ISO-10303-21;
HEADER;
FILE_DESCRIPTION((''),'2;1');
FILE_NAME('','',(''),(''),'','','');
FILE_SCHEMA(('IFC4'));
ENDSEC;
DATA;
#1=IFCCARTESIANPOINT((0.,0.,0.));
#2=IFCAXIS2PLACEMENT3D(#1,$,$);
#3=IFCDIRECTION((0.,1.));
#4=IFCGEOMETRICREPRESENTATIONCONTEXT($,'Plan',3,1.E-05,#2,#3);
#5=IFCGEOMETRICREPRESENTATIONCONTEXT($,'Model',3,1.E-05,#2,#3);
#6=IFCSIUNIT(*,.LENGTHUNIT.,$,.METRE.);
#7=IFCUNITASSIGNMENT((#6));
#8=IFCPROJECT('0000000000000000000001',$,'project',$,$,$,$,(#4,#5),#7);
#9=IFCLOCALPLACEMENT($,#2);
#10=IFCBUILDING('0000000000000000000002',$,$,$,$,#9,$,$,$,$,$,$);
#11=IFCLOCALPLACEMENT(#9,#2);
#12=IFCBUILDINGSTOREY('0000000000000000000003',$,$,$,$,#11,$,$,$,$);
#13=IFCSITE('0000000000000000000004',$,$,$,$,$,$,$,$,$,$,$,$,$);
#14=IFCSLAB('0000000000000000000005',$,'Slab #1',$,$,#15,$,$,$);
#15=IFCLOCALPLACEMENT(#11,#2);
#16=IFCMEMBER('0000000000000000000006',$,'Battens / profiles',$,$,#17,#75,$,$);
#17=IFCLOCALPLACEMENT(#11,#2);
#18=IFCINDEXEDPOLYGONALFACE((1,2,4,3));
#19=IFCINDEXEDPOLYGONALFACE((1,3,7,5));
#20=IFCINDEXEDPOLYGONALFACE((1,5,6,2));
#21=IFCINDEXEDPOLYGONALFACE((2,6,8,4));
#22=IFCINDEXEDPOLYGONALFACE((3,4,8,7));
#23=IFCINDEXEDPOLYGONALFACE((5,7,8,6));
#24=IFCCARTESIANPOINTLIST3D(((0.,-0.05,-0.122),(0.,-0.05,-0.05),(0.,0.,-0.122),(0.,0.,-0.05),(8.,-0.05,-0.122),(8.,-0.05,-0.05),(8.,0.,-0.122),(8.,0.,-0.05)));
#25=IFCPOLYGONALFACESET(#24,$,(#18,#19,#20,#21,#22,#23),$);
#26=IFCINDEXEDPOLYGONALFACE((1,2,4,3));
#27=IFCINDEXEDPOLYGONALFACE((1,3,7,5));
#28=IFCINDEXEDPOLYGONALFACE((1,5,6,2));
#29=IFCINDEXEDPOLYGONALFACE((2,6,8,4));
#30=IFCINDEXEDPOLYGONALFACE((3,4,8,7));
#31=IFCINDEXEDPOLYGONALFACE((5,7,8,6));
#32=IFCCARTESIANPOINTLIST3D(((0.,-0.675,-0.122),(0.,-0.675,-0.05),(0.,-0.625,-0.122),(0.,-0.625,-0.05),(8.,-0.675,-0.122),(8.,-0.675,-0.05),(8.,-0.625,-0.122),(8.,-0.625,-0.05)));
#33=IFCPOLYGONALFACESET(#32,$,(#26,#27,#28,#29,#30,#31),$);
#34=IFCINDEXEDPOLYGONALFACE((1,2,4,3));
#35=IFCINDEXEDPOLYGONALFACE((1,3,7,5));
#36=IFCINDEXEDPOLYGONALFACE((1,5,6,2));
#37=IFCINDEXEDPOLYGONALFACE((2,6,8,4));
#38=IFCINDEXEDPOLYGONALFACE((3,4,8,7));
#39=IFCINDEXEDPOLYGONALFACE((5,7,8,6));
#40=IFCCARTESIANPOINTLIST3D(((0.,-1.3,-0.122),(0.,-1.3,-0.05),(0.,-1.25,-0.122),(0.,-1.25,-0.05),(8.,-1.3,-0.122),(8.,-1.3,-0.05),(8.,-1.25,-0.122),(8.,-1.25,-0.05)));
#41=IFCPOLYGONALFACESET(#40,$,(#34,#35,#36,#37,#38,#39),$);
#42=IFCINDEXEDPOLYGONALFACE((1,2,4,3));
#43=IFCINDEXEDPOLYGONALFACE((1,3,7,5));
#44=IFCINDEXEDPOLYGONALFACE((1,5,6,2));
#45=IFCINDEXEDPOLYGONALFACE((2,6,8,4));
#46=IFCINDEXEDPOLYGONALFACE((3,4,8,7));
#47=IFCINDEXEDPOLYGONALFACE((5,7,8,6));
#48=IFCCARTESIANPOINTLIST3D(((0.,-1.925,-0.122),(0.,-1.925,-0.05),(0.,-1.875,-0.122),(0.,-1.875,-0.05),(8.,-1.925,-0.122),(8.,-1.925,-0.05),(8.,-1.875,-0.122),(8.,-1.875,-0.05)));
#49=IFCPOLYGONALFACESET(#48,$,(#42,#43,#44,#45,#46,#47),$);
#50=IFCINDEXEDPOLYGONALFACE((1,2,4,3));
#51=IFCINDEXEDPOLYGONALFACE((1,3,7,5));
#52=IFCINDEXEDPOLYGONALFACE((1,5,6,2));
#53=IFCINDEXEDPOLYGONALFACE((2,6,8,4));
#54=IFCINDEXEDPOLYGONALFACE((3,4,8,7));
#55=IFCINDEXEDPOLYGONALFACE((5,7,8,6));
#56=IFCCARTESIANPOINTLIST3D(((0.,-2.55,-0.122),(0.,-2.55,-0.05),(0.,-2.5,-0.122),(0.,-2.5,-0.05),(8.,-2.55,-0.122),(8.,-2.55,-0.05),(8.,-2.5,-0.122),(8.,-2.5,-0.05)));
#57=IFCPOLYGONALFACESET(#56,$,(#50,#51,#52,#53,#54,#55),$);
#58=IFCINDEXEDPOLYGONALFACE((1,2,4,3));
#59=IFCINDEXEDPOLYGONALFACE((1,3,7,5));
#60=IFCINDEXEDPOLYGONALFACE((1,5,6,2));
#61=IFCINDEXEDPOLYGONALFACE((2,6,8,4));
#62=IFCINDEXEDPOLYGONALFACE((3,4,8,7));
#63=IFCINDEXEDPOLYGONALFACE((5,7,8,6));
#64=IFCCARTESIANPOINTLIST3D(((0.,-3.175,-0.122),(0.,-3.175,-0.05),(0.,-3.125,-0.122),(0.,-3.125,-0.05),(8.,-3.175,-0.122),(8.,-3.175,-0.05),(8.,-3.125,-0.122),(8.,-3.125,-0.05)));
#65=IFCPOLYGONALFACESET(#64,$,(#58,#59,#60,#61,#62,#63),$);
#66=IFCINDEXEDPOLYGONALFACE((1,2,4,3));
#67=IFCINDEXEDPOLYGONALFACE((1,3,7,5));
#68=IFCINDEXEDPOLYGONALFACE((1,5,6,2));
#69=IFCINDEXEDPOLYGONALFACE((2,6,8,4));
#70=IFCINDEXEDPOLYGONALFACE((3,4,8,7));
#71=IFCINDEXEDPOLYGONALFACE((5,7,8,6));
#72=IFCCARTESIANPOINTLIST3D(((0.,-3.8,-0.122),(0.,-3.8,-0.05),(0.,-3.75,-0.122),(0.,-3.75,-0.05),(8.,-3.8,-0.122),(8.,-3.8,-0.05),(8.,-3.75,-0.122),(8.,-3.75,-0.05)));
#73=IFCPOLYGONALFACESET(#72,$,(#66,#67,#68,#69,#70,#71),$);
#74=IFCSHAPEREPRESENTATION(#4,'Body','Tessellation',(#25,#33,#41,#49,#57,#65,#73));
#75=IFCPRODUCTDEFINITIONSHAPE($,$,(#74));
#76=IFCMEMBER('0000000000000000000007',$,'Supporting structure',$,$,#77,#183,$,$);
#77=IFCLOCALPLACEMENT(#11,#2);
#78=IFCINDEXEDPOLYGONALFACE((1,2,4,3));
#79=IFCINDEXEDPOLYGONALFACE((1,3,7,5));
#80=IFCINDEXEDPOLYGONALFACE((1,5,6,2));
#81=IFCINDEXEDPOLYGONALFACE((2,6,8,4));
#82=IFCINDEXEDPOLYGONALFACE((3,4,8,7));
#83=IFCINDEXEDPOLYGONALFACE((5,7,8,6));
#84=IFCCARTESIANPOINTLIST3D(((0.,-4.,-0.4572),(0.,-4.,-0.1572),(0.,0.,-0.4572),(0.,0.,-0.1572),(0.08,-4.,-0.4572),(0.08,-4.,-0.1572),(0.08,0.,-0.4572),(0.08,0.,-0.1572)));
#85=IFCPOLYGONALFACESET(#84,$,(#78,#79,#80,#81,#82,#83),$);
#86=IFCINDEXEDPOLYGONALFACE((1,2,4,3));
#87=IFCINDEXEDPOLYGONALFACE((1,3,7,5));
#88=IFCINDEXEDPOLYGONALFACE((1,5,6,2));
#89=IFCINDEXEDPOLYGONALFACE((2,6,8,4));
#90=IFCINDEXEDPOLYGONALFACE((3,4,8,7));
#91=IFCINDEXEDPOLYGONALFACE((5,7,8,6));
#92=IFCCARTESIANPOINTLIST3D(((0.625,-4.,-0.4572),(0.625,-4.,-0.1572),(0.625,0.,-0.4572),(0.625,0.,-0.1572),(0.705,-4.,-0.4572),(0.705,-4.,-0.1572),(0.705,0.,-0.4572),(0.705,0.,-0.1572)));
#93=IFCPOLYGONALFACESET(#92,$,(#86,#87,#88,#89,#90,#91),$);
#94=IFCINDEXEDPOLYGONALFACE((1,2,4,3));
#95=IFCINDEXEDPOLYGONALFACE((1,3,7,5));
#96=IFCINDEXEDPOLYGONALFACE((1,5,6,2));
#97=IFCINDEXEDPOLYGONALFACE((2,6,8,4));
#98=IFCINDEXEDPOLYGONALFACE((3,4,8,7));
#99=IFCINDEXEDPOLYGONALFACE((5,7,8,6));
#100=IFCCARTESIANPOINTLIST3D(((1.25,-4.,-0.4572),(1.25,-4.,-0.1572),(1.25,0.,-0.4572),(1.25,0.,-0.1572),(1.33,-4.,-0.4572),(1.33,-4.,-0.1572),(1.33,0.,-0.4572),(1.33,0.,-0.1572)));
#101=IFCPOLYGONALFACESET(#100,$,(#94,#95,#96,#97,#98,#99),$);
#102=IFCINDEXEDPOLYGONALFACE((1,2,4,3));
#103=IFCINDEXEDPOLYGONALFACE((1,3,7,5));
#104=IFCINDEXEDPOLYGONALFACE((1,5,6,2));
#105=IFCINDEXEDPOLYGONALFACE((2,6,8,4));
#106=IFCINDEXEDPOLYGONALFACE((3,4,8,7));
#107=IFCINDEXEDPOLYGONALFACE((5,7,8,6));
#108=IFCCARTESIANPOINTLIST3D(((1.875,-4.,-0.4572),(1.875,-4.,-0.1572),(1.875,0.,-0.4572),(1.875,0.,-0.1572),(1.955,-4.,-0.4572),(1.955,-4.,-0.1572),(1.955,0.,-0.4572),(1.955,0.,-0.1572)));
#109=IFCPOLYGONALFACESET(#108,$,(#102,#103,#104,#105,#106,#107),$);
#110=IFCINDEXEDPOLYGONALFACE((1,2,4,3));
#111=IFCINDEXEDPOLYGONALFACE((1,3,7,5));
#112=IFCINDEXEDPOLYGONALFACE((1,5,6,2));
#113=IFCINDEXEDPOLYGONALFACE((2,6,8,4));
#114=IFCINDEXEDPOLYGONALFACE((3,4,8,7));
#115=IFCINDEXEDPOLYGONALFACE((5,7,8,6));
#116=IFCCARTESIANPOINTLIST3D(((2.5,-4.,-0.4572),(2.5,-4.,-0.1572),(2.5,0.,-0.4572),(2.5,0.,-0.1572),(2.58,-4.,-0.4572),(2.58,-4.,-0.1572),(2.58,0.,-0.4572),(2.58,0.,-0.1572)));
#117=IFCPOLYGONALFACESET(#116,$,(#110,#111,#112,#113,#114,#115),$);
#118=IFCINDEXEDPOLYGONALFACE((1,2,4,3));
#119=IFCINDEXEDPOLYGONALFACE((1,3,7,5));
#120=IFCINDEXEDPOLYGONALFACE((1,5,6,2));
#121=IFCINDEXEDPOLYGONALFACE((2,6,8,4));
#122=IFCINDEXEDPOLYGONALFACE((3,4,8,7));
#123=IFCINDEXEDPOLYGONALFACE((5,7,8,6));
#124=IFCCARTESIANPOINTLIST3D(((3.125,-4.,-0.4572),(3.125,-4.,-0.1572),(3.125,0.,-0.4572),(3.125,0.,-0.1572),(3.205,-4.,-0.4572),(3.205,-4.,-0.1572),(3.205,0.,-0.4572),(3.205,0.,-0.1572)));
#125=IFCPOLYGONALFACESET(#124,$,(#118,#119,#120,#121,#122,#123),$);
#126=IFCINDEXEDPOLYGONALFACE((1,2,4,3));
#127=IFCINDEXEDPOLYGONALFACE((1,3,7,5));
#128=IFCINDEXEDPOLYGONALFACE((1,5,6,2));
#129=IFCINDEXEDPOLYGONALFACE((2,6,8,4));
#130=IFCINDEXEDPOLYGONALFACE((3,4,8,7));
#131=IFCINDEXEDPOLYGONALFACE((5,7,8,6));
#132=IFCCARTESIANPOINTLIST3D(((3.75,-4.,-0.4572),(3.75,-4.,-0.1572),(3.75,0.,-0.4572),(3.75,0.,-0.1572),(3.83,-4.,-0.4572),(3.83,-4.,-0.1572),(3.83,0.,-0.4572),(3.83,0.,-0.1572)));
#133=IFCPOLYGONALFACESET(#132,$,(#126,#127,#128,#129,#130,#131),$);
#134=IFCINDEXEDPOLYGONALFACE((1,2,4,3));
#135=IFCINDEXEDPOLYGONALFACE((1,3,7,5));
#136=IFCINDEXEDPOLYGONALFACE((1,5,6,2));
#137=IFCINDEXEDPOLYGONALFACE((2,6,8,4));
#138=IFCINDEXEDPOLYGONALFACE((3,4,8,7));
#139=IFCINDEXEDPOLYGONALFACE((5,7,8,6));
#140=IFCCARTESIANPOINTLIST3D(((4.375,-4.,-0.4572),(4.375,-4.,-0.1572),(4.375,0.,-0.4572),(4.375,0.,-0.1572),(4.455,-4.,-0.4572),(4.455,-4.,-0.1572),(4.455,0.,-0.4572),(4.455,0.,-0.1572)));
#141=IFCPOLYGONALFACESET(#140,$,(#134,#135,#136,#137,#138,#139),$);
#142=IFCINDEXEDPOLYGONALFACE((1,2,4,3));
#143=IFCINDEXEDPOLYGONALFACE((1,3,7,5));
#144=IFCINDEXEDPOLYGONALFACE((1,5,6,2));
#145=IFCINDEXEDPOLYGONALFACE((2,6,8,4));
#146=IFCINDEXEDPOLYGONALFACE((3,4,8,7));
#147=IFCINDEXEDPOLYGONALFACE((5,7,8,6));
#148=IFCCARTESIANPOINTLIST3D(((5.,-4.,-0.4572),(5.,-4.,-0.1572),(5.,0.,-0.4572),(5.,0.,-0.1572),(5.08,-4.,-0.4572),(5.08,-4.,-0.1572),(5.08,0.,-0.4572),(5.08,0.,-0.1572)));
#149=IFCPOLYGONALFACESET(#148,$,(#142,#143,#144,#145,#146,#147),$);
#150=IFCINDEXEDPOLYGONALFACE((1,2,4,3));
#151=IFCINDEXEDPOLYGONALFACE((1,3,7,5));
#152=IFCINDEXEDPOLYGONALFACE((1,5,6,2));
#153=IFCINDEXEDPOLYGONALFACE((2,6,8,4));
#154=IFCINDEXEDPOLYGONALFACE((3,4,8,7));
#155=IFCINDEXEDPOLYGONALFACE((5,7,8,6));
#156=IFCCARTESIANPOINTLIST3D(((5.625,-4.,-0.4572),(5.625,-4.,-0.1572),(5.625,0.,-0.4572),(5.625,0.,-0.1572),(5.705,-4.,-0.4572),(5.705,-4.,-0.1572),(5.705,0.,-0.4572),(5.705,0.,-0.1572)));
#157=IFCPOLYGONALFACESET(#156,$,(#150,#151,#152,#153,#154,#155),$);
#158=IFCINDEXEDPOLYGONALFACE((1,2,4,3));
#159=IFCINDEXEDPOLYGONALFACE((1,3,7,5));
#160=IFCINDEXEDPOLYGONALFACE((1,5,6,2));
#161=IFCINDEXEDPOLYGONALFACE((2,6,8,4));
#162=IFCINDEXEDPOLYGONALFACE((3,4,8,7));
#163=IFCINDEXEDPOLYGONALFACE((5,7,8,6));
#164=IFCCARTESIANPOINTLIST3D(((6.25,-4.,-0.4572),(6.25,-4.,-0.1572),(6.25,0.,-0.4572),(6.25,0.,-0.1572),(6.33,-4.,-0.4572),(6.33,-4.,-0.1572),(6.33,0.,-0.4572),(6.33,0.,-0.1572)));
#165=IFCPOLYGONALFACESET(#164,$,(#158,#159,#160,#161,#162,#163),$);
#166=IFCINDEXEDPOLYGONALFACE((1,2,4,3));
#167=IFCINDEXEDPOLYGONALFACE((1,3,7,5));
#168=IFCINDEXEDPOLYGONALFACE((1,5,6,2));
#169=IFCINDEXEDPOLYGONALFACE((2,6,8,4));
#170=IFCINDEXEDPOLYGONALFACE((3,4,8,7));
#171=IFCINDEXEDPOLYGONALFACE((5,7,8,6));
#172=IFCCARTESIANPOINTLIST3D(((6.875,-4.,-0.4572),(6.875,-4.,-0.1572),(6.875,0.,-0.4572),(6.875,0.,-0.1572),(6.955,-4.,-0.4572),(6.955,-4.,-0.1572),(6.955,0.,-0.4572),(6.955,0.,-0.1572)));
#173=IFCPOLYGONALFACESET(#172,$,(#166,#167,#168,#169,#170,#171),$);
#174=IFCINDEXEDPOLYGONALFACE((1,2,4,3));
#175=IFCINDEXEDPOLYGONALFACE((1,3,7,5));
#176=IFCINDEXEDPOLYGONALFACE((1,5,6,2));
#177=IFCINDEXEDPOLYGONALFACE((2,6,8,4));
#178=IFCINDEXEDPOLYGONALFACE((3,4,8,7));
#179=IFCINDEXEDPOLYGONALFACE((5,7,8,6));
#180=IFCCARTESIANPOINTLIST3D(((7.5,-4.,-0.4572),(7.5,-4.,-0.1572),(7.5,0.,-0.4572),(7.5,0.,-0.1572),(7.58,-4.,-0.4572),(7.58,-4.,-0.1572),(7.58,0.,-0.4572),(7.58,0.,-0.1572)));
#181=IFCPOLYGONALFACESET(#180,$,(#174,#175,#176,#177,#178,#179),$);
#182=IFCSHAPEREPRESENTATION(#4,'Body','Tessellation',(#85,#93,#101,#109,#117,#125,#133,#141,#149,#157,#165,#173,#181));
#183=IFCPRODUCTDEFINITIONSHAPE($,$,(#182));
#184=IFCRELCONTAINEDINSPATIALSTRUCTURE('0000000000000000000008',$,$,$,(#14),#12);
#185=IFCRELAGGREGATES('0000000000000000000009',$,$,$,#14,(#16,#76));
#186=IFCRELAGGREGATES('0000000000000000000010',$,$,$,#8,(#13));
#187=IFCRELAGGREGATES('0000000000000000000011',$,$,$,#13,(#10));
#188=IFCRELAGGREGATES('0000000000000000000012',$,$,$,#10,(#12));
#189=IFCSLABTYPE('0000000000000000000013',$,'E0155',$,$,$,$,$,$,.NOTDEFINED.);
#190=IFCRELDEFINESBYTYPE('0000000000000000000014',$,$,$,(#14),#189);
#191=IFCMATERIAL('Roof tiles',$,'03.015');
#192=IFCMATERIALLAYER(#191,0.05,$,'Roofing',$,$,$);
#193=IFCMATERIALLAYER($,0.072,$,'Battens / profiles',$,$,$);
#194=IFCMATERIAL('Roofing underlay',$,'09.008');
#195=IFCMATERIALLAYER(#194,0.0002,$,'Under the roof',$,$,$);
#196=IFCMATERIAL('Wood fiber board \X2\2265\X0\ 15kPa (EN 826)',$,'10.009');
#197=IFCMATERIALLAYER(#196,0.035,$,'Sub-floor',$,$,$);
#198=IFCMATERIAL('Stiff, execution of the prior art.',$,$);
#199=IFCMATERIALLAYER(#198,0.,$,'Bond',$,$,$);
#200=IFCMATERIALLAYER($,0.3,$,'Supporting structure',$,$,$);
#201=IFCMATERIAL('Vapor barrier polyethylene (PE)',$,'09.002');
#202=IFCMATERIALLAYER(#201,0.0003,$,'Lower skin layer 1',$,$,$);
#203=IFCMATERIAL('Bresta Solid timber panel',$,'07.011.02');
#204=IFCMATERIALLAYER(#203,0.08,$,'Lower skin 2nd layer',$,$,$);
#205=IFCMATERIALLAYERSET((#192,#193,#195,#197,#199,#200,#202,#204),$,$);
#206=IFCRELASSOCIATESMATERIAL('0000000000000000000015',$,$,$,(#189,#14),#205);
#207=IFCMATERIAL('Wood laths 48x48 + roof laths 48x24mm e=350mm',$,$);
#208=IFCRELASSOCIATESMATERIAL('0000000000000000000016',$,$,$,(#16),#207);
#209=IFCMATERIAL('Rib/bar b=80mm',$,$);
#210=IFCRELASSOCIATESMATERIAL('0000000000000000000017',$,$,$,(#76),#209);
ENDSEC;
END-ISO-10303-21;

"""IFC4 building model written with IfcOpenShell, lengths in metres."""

from ifc_helpers import new_model, si_unit, direction, frame, frame_2d, origin, place, context, project, spatial, rectangle, extrude, material, layer, layer_set, type_object, element, aggregate, save


model = new_model("IFC4")

# Units and contexts
plan_context = context("Plan", 3, precision=1e-05, world=origin(), true_north=direction((0.0, 1.0)))
model_context = context("Model", 3, precision=1e-05, world=origin(), true_north=direction((0.0, 1.0)))
ifc_project = project(units=[si_unit("LENGTHUNIT", "METRE")], contexts=[plan_context, model_context])

# Site, building, storey
site = spatial("IfcSite", under=ifc_project)
building_placement = place(None, origin())
building = spatial("IfcBuilding", under=site, at=building_placement)
storey_placement = place(building_placement, origin())
storey = spatial("IfcBuildingStorey", under=building, at=storey_placement)

# Slab, members
ifc_material_1 = material(Name="Roof tiles", Category="03.015")
ifc_layer_1 = layer(ifc_material_1, 0.05, Name="Roofing")
ifc_layer_2 = layer(None, 0.072, Name="Battens / profiles")
ifc_material_2 = material(Name="Roofing underlay", Category="09.008")
ifc_layer_3 = layer(ifc_material_2, 0.0002, Name="Under the roof")
ifc_material_3 = material(Name="Wood fiber board ≥ 15kPa (EN 826)", Category="10.009")
ifc_layer_4 = layer(ifc_material_3, 0.035, Name="Sub-floor")
ifc_material_4 = material(Name="Stiff, execution of the prior art.")
ifc_layer_5 = layer(ifc_material_4, 0.0, Name="Bond")
ifc_layer_6 = layer(None, 0.3, Name="Supporting structure")
ifc_material_5 = material(Name="Vapor barrier polyethylene (PE)", Category="09.002")
ifc_layer_7 = layer(ifc_material_5, 0.0003, Name="Lower skin layer 1")
ifc_material_6 = material(Name="Bresta Solid timber panel", Category="07.011.02")
ifc_layer_8 = layer(ifc_material_6, 0.08, Name="Lower skin 2nd layer")
ifc_layer_set = layer_set([ifc_layer_1, ifc_layer_2, ifc_layer_3, ifc_layer_4, ifc_layer_5, ifc_layer_6, ifc_layer_7, ifc_layer_8])
slab_type = type_object("IfcSlabType", Name="E0155", PredefinedType="NOTDEFINED", material=ifc_layer_set)
slab_placement = place(None, frame((0.0, 0.0, 0.0), z_axis=(0.0, 0.0, -1.0), x_axis=(1.0, 0.0, 0.0)))
slab = element("IfcSlab", 1, at=slab_placement, inside=storey, type_object=slab_type, material=ifc_layer_set, Name="Slab #1")
ifc_material_7 = material(Name="Wood laths 48x48 + roof laths 48x24mm e=350mm")
member_1_placement = place(slab_placement, origin())
member_1 = element("IfcMember", 2, at=member_1_placement, material=ifc_material_7, Name="Battens / profiles", context=plan_context, shape_type="SweptSolid", body=[
    extrude(rectangle(XDim=0.05, YDim=0.072, at=frame_2d((0.025, 0.036), x_axis=(1.0, 0.0))), frame((0.0, 0.0, 0.05), z_axis=(1.0, 0.0, 0.0), x_axis=(0.0, 1.0, 0.0)), (0.0, 0.0, 1.0), 8.0),
    extrude(rectangle(XDim=0.05, YDim=0.072, at=frame_2d((0.025, 0.036), x_axis=(1.0, 0.0))), frame((0.0, 0.625, 0.05), z_axis=(1.0, 0.0, 0.0), x_axis=(0.0, 1.0, 0.0)), (0.0, 0.0, 1.0), 8.0),
    extrude(rectangle(XDim=0.05, YDim=0.072, at=frame_2d((0.025, 0.036), x_axis=(1.0, 0.0))), frame((0.0, 1.25, 0.05), z_axis=(1.0, 0.0, 0.0), x_axis=(0.0, 1.0, 0.0)), (0.0, 0.0, 1.0), 8.0),
    extrude(rectangle(XDim=0.05, YDim=0.072, at=frame_2d((0.025, 0.036), x_axis=(1.0, 0.0))), frame((0.0, 1.875, 0.05), z_axis=(1.0, 0.0, 0.0), x_axis=(0.0, 1.0, 0.0)), (0.0, 0.0, 1.0), 8.0),
    extrude(rectangle(XDim=0.05, YDim=0.072, at=frame_2d((0.025, 0.036), x_axis=(1.0, 0.0))), frame((0.0, 2.5, 0.05), z_axis=(1.0, 0.0, 0.0), x_axis=(0.0, 1.0, 0.0)), (0.0, 0.0, 1.0), 8.0),
    extrude(rectangle(XDim=0.05, YDim=0.072, at=frame_2d((0.025, 0.036), x_axis=(1.0, 0.0))), frame((0.0, 3.125, 0.05), z_axis=(1.0, 0.0, 0.0), x_axis=(0.0, 1.0, 0.0)), (0.0, 0.0, 1.0), 8.0),
    extrude(rectangle(XDim=0.05, YDim=0.072, at=frame_2d((0.025, 0.036), x_axis=(1.0, 0.0))), frame((0.0, 3.75, 0.05), z_axis=(1.0, 0.0, 0.0), x_axis=(0.0, 1.0, 0.0)), (0.0, 0.0, 1.0), 8.0),
])
ifc_material_8 = material(Name="Rib/bar b=80mm")
member_2_placement = place(slab_placement, origin())
member_2 = element("IfcMember", 3, at=member_2_placement, material=ifc_material_8, Name="Supporting structure", context=plan_context, shape_type="SweptSolid", body=[
    extrude(rectangle(XDim=0.08, YDim=0.3, at=frame_2d((0.04, 0.15), x_axis=(1.0, 0.0))), frame((0.0, 4.0, 0.1572), z_axis=(0.0, -1.0, 0.0), x_axis=(1.0, 0.0, 0.0)), (0.0, 0.0, 1.0), 4.0),
    extrude(rectangle(XDim=0.08, YDim=0.3, at=frame_2d((0.04, 0.15), x_axis=(1.0, 0.0))), frame((0.625, 4.0, 0.1572), z_axis=(0.0, -1.0, 0.0), x_axis=(1.0, 0.0, 0.0)), (0.0, 0.0, 1.0), 4.0),
    extrude(rectangle(XDim=0.08, YDim=0.3, at=frame_2d((0.04, 0.15), x_axis=(1.0, 0.0))), frame((1.25, 4.0, 0.1572), z_axis=(0.0, -1.0, 0.0), x_axis=(1.0, 0.0, 0.0)), (0.0, 0.0, 1.0), 4.0),
    extrude(rectangle(XDim=0.08, YDim=0.3, at=frame_2d((0.04, 0.15), x_axis=(1.0, 0.0))), frame((1.875, 4.0, 0.1572), z_axis=(0.0, -1.0, 0.0), x_axis=(1.0, 0.0, 0.0)), (0.0, 0.0, 1.0), 4.0),
    extrude(rectangle(XDim=0.08, YDim=0.3, at=frame_2d((0.04, 0.15), x_axis=(1.0, 0.0))), frame((2.5, 4.0, 0.1572), z_axis=(0.0, -1.0, 0.0), x_axis=(1.0, 0.0, 0.0)), (0.0, 0.0, 1.0), 4.0),
    extrude(rectangle(XDim=0.08, YDim=0.3, at=frame_2d((0.04, 0.15), x_axis=(1.0, 0.0))), frame((3.125, 4.0, 0.1572), z_axis=(0.0, -1.0, 0.0), x_axis=(1.0, 0.0, 0.0)), (0.0, 0.0, 1.0), 4.0),
    extrude(rectangle(XDim=0.08, YDim=0.3, at=frame_2d((0.04, 0.15), x_axis=(1.0, 0.0))), frame((3.75, 4.0, 0.1572), z_axis=(0.0, -1.0, 0.0), x_axis=(1.0, 0.0, 0.0)), (0.0, 0.0, 1.0), 4.0),
    extrude(rectangle(XDim=0.08, YDim=0.3, at=frame_2d((0.04, 0.15), x_axis=(1.0, 0.0))), frame((4.375, 4.0, 0.1572), z_axis=(0.0, -1.0, 0.0), x_axis=(1.0, 0.0, 0.0)), (0.0, 0.0, 1.0), 4.0),
    extrude(rectangle(XDim=0.08, YDim=0.3, at=frame_2d((0.04, 0.15), x_axis=(1.0, 0.0))), frame((5.0, 4.0, 0.1572), z_axis=(0.0, -1.0, 0.0), x_axis=(1.0, 0.0, 0.0)), (0.0, 0.0, 1.0), 4.0),
    extrude(rectangle(XDim=0.08, YDim=0.3, at=frame_2d((0.04, 0.15), x_axis=(1.0, 0.0))), frame((5.625, 4.0, 0.1572), z_axis=(0.0, -1.0, 0.0), x_axis=(1.0, 0.0, 0.0)), (0.0, 0.0, 1.0), 4.0),
    extrude(rectangle(XDim=0.08, YDim=0.3, at=frame_2d((0.04, 0.15), x_axis=(1.0, 0.0))), frame((6.25, 4.0, 0.1572), z_axis=(0.0, -1.0, 0.0), x_axis=(1.0, 0.0, 0.0)), (0.0, 0.0, 1.0), 4.0),
    extrude(rectangle(XDim=0.08, YDim=0.3, at=frame_2d((0.04, 0.15), x_axis=(1.0, 0.0))), frame((6.875, 4.0, 0.1572), z_axis=(0.0, -1.0, 0.0), x_axis=(1.0, 0.0, 0.0)), (0.0, 0.0, 1.0), 4.0),
    extrude(rectangle(XDim=0.08, YDim=0.3, at=frame_2d((0.04, 0.15), x_axis=(1.0, 0.0))), frame((7.5, 4.0, 0.1572), z_axis=(0.0, -1.0, 0.0), x_axis=(1.0, 0.0, 0.0)), (0.0, 0.0, 1.0), 4.0),
])
aggregate(slab, [member_1, member_2])

save(model, "model.ifc")
